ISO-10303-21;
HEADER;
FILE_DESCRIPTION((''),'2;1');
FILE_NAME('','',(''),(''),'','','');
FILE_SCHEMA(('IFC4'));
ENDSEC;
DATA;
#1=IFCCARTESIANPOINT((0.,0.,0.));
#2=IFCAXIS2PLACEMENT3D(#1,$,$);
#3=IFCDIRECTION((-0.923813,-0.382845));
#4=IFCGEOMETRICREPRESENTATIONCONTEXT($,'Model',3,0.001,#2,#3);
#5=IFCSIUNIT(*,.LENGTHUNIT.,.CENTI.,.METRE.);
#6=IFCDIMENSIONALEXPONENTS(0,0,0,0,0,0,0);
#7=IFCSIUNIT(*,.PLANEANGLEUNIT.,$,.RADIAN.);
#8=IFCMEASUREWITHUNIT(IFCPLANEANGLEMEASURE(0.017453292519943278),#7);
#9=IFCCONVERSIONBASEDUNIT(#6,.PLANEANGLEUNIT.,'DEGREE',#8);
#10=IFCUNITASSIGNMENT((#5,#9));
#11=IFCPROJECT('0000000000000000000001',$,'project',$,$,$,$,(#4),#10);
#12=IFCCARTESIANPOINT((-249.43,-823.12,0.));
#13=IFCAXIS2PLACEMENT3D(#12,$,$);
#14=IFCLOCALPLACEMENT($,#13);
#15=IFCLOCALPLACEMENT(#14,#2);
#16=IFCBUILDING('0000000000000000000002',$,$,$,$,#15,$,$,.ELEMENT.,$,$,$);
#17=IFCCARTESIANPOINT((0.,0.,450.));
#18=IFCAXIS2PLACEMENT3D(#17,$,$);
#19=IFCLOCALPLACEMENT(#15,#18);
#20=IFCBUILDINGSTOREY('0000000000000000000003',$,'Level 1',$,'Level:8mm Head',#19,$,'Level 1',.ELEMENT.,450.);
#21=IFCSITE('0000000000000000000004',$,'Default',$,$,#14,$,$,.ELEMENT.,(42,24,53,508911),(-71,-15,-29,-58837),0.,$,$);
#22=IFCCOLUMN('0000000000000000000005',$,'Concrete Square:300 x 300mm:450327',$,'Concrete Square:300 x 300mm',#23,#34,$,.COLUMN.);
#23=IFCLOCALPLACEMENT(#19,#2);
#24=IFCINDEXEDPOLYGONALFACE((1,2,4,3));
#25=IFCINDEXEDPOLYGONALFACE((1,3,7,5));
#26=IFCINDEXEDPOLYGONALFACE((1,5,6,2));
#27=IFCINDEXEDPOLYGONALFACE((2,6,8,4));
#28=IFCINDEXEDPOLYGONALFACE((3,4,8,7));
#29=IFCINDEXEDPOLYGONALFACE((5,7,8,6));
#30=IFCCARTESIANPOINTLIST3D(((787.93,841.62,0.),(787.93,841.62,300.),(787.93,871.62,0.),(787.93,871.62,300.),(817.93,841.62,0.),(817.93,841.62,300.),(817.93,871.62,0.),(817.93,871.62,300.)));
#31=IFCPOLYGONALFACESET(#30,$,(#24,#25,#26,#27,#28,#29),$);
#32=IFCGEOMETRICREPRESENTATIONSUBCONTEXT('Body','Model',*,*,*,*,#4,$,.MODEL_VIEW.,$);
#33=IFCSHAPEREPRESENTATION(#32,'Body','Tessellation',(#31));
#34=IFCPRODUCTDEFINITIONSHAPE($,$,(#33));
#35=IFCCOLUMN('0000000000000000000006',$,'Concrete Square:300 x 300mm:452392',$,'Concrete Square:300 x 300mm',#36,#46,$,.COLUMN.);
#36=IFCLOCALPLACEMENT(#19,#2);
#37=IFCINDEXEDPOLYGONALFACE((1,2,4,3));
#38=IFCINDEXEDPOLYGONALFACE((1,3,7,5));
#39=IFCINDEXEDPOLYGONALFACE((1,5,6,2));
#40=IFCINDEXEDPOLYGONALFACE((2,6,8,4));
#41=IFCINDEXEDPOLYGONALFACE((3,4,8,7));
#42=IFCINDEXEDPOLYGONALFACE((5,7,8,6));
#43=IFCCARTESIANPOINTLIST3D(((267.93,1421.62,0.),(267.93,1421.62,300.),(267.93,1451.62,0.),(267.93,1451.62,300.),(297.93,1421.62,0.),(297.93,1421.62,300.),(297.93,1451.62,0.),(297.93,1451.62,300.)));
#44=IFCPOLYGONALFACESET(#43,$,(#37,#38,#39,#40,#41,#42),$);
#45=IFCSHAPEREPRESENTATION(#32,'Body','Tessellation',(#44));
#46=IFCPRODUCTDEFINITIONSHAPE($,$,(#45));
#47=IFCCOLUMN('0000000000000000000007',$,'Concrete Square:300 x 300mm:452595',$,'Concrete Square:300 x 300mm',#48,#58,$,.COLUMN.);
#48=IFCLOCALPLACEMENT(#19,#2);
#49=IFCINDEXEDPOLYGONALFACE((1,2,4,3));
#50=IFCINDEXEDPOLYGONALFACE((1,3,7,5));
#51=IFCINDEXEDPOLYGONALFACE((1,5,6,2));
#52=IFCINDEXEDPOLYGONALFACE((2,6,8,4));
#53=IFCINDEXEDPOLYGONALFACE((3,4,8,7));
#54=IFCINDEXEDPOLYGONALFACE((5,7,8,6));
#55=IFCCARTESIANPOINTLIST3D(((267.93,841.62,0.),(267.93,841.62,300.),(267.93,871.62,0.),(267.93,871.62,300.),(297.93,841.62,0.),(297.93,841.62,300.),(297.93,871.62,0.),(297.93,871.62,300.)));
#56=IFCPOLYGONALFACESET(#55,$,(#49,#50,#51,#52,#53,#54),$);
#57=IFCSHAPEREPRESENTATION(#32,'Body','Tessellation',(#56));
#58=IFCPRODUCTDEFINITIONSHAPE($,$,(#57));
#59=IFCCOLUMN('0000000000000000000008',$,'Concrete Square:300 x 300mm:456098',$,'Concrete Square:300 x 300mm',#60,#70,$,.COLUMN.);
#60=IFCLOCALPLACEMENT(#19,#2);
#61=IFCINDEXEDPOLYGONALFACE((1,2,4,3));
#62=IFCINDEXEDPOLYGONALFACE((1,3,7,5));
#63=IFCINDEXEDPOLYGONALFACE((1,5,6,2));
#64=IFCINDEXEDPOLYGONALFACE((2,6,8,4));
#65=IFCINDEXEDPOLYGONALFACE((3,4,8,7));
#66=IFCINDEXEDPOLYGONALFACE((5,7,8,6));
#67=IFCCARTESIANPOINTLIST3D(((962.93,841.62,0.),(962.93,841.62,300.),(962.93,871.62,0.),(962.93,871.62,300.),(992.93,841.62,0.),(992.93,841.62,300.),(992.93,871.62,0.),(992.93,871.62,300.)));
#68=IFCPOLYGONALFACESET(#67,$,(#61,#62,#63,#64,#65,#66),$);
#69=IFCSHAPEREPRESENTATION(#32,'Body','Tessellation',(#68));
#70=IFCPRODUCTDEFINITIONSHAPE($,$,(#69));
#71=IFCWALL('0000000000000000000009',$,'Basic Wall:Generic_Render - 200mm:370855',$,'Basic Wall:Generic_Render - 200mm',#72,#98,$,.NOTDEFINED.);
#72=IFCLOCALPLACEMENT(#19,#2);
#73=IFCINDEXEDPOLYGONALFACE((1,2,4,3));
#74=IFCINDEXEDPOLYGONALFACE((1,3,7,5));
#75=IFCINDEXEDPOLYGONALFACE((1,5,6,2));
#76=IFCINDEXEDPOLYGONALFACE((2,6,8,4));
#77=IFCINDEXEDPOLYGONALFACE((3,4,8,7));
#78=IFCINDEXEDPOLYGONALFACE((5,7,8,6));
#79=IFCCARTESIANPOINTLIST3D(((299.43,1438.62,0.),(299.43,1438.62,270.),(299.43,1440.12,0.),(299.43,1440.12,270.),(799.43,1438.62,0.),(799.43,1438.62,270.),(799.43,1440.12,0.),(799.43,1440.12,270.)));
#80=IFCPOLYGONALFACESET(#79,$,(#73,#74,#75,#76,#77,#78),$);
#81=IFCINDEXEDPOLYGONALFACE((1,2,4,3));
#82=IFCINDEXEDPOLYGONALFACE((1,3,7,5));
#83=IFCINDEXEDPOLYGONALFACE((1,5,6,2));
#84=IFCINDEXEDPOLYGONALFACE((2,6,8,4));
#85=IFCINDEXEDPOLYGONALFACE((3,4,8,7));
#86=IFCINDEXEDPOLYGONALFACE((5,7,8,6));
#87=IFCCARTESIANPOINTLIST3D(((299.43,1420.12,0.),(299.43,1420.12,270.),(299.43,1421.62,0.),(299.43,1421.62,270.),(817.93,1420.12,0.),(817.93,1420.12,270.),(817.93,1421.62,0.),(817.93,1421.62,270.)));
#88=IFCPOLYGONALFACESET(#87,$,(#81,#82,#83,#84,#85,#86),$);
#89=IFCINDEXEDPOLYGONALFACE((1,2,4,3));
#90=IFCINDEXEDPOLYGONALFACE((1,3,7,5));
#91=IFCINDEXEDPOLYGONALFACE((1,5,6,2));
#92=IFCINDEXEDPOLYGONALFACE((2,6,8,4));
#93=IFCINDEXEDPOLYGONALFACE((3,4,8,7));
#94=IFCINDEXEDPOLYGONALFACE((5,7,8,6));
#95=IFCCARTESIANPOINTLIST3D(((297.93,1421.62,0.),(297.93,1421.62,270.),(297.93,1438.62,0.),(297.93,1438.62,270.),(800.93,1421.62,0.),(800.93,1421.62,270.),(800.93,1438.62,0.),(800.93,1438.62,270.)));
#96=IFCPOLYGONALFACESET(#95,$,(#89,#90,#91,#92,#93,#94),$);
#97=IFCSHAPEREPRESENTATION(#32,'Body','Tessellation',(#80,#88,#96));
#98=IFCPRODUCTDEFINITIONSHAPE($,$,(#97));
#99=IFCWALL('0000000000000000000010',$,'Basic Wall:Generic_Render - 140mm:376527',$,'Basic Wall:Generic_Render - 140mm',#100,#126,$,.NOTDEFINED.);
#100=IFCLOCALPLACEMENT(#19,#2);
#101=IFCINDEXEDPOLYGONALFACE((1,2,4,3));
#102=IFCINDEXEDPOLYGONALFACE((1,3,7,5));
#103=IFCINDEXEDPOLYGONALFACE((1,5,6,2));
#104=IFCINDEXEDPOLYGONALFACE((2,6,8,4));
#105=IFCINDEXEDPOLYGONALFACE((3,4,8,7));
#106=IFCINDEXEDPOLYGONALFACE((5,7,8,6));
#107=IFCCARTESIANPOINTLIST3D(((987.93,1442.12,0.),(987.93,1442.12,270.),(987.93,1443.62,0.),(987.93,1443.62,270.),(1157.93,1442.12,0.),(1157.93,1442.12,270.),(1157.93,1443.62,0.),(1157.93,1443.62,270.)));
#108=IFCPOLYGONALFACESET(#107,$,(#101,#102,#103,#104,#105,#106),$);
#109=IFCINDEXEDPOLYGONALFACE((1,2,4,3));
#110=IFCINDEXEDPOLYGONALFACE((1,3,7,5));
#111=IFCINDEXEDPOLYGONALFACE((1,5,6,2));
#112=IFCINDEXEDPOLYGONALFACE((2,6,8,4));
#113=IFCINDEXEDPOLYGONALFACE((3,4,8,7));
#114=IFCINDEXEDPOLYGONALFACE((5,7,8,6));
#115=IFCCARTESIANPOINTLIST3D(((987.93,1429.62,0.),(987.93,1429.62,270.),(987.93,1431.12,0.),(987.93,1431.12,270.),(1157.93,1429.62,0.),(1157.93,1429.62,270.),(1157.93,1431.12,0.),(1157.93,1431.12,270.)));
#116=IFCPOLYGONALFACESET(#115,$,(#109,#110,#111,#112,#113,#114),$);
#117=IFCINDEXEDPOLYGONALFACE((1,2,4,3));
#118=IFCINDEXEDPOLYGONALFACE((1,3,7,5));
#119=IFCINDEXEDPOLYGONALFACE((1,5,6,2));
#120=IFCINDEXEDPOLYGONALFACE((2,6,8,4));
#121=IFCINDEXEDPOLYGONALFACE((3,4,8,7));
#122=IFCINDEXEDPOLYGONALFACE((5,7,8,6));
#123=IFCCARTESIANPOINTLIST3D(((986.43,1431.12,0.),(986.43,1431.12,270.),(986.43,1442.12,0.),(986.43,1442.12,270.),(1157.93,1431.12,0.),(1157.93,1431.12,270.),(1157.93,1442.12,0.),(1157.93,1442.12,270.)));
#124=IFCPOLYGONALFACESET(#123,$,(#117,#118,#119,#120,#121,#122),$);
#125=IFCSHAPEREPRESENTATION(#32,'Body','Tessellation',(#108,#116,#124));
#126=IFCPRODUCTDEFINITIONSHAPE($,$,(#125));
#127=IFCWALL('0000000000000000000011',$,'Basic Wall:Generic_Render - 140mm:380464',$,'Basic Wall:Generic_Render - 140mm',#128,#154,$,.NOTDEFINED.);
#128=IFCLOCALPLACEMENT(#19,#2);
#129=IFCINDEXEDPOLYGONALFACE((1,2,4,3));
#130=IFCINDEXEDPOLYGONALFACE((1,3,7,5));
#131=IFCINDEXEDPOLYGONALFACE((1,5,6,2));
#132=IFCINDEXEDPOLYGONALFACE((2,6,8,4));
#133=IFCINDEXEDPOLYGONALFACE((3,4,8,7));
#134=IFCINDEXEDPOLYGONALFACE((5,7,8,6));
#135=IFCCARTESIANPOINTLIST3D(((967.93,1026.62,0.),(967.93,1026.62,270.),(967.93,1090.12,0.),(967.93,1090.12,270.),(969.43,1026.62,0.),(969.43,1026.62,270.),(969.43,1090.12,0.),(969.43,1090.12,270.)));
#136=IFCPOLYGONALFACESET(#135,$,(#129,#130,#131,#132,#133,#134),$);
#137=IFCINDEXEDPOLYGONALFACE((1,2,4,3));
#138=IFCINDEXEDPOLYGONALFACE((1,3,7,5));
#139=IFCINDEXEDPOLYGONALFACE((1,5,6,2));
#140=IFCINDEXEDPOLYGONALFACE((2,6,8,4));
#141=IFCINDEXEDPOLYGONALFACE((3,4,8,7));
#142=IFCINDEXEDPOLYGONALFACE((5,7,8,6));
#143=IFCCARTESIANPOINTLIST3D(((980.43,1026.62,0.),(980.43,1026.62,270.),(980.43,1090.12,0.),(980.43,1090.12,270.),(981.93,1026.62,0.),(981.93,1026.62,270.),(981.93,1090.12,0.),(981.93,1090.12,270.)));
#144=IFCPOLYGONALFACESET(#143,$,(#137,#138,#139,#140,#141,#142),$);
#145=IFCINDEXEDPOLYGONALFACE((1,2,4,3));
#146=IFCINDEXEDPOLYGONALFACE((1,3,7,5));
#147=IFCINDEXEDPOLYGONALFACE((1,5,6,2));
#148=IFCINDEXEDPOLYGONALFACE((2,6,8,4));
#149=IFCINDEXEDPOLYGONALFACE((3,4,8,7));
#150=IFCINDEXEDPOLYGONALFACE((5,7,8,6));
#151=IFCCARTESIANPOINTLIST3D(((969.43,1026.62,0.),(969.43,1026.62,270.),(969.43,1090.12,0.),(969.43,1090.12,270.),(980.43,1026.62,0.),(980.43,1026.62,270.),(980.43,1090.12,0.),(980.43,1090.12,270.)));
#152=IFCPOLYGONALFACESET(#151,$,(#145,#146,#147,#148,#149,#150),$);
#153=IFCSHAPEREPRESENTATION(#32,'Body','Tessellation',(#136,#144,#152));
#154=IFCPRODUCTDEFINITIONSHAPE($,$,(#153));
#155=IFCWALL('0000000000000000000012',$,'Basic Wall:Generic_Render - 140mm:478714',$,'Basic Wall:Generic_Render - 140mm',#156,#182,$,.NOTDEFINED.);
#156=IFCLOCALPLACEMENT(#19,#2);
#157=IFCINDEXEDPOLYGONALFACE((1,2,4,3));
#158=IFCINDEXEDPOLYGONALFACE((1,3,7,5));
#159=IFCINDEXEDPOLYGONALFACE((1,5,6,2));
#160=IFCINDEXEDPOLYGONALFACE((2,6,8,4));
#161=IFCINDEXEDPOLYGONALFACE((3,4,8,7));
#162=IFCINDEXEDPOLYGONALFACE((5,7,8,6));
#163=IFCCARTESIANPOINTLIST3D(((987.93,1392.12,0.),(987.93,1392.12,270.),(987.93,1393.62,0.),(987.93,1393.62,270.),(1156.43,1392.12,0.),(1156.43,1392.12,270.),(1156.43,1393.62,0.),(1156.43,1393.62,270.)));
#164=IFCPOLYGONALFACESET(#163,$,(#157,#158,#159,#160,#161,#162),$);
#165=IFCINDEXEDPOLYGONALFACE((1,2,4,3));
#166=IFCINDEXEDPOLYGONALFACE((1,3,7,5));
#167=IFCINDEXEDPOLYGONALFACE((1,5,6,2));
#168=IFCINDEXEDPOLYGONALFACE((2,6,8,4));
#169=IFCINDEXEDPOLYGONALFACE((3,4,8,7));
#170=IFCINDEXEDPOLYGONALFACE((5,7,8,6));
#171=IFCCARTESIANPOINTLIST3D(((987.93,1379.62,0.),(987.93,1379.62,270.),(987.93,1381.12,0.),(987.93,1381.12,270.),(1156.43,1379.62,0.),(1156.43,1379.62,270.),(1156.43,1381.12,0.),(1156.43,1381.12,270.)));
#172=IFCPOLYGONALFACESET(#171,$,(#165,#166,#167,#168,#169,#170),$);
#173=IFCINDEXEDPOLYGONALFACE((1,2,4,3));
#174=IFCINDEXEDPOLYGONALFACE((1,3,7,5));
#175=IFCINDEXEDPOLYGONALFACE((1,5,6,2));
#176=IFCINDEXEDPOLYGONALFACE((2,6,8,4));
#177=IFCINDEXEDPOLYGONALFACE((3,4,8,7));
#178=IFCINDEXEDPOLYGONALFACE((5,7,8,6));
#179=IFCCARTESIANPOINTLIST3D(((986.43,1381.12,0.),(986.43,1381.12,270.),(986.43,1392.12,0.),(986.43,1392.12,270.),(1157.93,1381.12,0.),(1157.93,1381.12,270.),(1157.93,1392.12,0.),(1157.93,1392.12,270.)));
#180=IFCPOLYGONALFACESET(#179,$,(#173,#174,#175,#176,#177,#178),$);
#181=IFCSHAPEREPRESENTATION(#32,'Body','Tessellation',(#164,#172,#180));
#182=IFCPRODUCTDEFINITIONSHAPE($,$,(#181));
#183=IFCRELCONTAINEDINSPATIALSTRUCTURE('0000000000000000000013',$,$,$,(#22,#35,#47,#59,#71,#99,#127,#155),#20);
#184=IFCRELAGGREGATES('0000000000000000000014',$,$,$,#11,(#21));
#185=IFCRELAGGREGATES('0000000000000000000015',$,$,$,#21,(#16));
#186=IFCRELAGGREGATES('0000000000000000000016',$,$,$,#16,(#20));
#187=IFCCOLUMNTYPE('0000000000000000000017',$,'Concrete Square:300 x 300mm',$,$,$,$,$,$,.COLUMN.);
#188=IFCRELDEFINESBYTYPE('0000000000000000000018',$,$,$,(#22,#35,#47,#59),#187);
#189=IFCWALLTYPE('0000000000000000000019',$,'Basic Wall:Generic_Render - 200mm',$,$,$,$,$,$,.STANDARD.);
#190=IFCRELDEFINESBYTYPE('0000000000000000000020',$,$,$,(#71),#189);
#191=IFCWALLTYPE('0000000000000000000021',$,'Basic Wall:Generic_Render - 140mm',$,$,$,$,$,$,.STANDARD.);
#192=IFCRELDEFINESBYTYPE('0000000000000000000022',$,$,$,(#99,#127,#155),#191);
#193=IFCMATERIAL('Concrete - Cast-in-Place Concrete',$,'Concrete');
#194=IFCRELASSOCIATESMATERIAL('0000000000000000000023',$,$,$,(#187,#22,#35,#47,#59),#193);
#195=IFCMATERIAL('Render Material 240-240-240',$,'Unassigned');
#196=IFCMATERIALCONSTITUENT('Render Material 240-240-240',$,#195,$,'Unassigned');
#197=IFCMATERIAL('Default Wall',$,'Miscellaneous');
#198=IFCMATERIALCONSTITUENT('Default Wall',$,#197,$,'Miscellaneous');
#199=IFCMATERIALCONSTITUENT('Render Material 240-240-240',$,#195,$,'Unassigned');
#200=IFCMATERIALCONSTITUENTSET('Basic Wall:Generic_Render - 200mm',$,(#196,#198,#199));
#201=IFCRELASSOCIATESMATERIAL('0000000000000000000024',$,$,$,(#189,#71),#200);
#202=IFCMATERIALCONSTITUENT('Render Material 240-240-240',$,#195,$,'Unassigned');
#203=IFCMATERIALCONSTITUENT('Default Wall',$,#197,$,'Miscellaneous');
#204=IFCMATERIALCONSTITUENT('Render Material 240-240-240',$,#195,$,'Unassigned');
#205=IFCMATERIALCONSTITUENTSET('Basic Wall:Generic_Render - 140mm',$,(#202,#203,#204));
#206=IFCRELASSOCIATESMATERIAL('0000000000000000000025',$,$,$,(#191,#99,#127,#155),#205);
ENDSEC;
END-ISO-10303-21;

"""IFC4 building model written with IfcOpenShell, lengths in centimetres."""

from ifc_helpers import new_model, entity, si_unit, converted_unit, direction, frame, origin, place, context, subcontext, project, spatial, indexed_curve, outline, extrude, source, transform, mapped, material, constituent, constituent_set, type_object, type_shapes, element, save


model = new_model("IFC4")

# Units and contexts
model_context = context("Model", 3, precision=0.001, world=origin(), true_north=direction((-0.923813, -0.382845)))
body_context = subcontext(model_context, "Body", "Model", "MODEL_VIEW")
ifc_project = project(units=[si_unit("LENGTHUNIT", "METRE", prefix="CENTI"), converted_unit("PLANEANGLEUNIT", "DEGREE", entity("IfcPlaneAngleMeasure", 0.017453292519943278), si_unit("PLANEANGLEUNIT", "RADIAN"), dimensions=[0, 0, 0, 0, 0, 0, 0])], contexts=[model_context])

# Site, building, storey
site_placement = place(None, frame((-249.43, -823.12, 0.0)))
site = spatial("IfcSite", under=ifc_project, at=site_placement, Name="Default", CompositionType="ELEMENT", RefLatitude=(42, 24, 53, 508911), RefLongitude=(-71, -15, -29, -58837), RefElevation=0.0)
building_placement = place(site_placement, origin())
building = spatial("IfcBuilding", under=site, at=building_placement, CompositionType="ELEMENT")
storey_placement = place(building_placement, frame((0.0, 0.0, 450.0)))
storey = spatial("IfcBuildingStorey", under=building, at=storey_placement, Name="Level 1", ObjectType="Level:8mm Head", LongName="Level 1", CompositionType="ELEMENT", Elevation=450.0)

# Columns
ifc_material_1 = material(Name="Concrete - Cast-in-Place Concrete", Category="Concrete")
column_type = type_object("IfcColumnType", Name="Concrete Square:300 x 300mm", PredefinedType="COLUMN", material=ifc_material_1)
shared_shape_1 = source(origin(), body_context, "Body", "SweptSolid", [
    extrude(outline(indexed_curve([(-15.0, -15.0), (15.0, -15.0), (15.0, 15.0), (-15.0, 15.0), (-15.0, -15.0)], self_intersect=False)), frame((0.0, 0.0, 450.0), z_axis=(0.0, 0.0, 1.0), x_axis=(-1.0, 0.0, 0.0)), (0.0, 0.0, 1.0), 300.0),
])
type_shapes(column_type, [shared_shape_1])
for number, where, name in (
    (1, (802.93, 856.62, -450.0), "Concrete Square:300 x 300mm:450327"),
    (2, (282.93, 1436.62, -450.0), "Concrete Square:300 x 300mm:452392"),
    (3, (282.93, 856.62, -450.0), "Concrete Square:300 x 300mm:452595"),
    (4, (977.93, 856.62, -450.0), "Concrete Square:300 x 300mm:456098"),
):
    element("IfcColumn", number, at=place(storey_placement, frame(where)), inside=storey, type_object=column_type, material=ifc_material_1, Name=name, ObjectType="Concrete Square:300 x 300mm", PredefinedType="COLUMN", context=body_context, shape_type="MappedRepresentation", body=[
        mapped(shared_shape_1, transform((0.0, 0.0, 0.0), scale=1.0)),
    ])

# Walls
ifc_material_2 = material(Name="Render Material 240-240-240", Category="Unassigned")
ifc_constituent_1 = constituent(ifc_material_2, Name="Render Material 240-240-240", Category="Unassigned")
ifc_material_3 = material(Name="Default Wall", Category="Miscellaneous")
ifc_constituent_2 = constituent(ifc_material_3, Name="Default Wall", Category="Miscellaneous")
ifc_constituent_3 = constituent(ifc_material_2, Name="Render Material 240-240-240", Category="Unassigned")
ifc_constituent_set_1 = constituent_set(constituents=[ifc_constituent_1, ifc_constituent_2, ifc_constituent_3], Name="Basic Wall:Generic_Render - 200mm")
wall_type_1 = type_object("IfcWallType", Name="Basic Wall:Generic_Render - 200mm", PredefinedType="STANDARD", material=ifc_constituent_set_1)
wall_1_placement = place(storey_placement, frame((799.43, 1430.12, 0.0), z_axis=(0.0, 0.0, 1.0), x_axis=(-1.0, 0.0, 0.0)))
element("IfcWall", 5, at=wall_1_placement, inside=storey, type_object=wall_type_1, material=ifc_constituent_set_1, Name="Basic Wall:Generic_Render - 200mm:370855", ObjectType="Basic Wall:Generic_Render - 200mm", PredefinedType="NOTDEFINED", context=body_context, shape_type="SweptSolid", body=[
    extrude(outline(indexed_curve([(-0.75, -250.0), (0.75, -250.0), (0.75, 250.0), (-0.75, 250.0), (-0.75, -250.0)], self_intersect=False)), frame((250.0, -9.25, 0.0), z_axis=(0.0, 0.0, 1.0), x_axis=(0.0, 1.0, 0.0)), (0.0, 0.0, 1.0), 270.0),
    extrude(outline(indexed_curve([(-0.75, -259.25), (0.75, -259.25), (0.75, 259.25), (-0.75, 259.25), (-0.75, -259.25)], self_intersect=False)), frame((240.75, 9.25, 0.0), z_axis=(0.0, 0.0, 1.0), x_axis=(0.0, -1.0, 0.0)), (0.0, 0.0, 1.0), 270.0),
    extrude(outline(indexed_curve([(-251.5, -8.5), (251.5, -8.5), (251.5, 8.5), (-251.5, 8.5), (-251.5, -8.5)], self_intersect=False)), frame((250.0, 0.0, 0.0)), (0.0, 0.0, 1.0), 270.0),
])
ifc_constituent_4 = constituent(ifc_material_2, Name="Render Material 240-240-240", Category="Unassigned")
ifc_constituent_5 = constituent(ifc_material_3, Name="Default Wall", Category="Miscellaneous")
ifc_constituent_6 = constituent(ifc_material_2, Name="Render Material 240-240-240", Category="Unassigned")
ifc_constituent_set_2 = constituent_set(constituents=[ifc_constituent_4, ifc_constituent_5, ifc_constituent_6], Name="Basic Wall:Generic_Render - 140mm")
wall_type_2 = type_object("IfcWallType", Name="Basic Wall:Generic_Render - 140mm", PredefinedType="STANDARD", material=ifc_constituent_set_2)
wall_2_placement = place(storey_placement, frame((1157.93, 1436.62, 0.0), z_axis=(0.0, 0.0, 1.0), x_axis=(-1.0, 0.0, 0.0)))
element("IfcWall", 6, at=wall_2_placement, inside=storey, type_object=wall_type_2, material=ifc_constituent_set_2, Name="Basic Wall:Generic_Render - 140mm:376527", ObjectType="Basic Wall:Generic_Render - 140mm", PredefinedType="NOTDEFINED", context=body_context, shape_type="SweptSolid", body=[
    extrude(outline(indexed_curve([(-0.75, -85.0), (0.75, -85.0), (0.75, 85.0), (-0.75, 85.0), (-0.75, -85.0)], self_intersect=False)), frame((85.0, -6.25, 0.0), z_axis=(0.0, 0.0, 1.0), x_axis=(0.0, 1.0, 0.0)), (0.0, 0.0, 1.0), 270.0),
    extrude(outline(indexed_curve([(-0.75, -85.0), (0.75, -85.0), (0.75, 85.0), (-0.75, 85.0), (-0.75, -85.0)], self_intersect=False)), frame((85.0, 6.25, 0.0), z_axis=(0.0, 0.0, 1.0), x_axis=(0.0, -1.0, 0.0)), (0.0, 0.0, 1.0), 270.0),
    extrude(outline(indexed_curve([(-85.75, -5.5), (85.75, -5.5), (85.75, 5.5), (-85.75, 5.5), (-85.75, -5.5)], self_intersect=False)), frame((85.75, 0.0, 0.0)), (0.0, 0.0, 1.0), 270.0),
])
wall_3_placement = place(storey_placement, frame((974.93, 1090.12, 0.0), z_axis=(0.0, 0.0, 1.0), x_axis=(0.0, -1.0, 0.0)))
element("IfcWall", 7, at=wall_3_placement, inside=storey, type_object=wall_type_2, material=ifc_constituent_set_2, Name="Basic Wall:Generic_Render - 140mm:380464", ObjectType="Basic Wall:Generic_Render - 140mm", PredefinedType="NOTDEFINED", context=body_context, shape_type="SweptSolid", body=[
    extrude(outline(indexed_curve([(-0.75, -31.75), (0.75, -31.75), (0.75, 31.75), (-0.75, 31.75), (-0.75, -31.75)], self_intersect=False)), frame((31.75, -6.25, 0.0), z_axis=(0.0, 0.0, 1.0), x_axis=(0.0, 1.0, 0.0)), (0.0, 0.0, 1.0), 270.0),
    extrude(outline(indexed_curve([(-0.75, -31.75), (0.75, -31.75), (0.75, 31.75), (-0.75, 31.75), (-0.75, -31.75)], self_intersect=False)), frame((31.75, 6.25, 0.0), z_axis=(0.0, 0.0, 1.0), x_axis=(0.0, -1.0, 0.0)), (0.0, 0.0, 1.0), 270.0),
    extrude(outline(indexed_curve([(-31.75, -5.5), (31.75, -5.5), (31.75, 5.5), (-31.75, 5.5), (-31.75, -5.5)], self_intersect=False)), frame((31.75, 0.0, 0.0)), (0.0, 0.0, 1.0), 270.0),
])
wall_4_placement = place(storey_placement, frame((1156.43, 1386.62, 0.0), z_axis=(0.0, 0.0, 1.0), x_axis=(-1.0, 0.0, 0.0)))
element("IfcWall", 8, at=wall_4_placement, inside=storey, type_object=wall_type_2, material=ifc_constituent_set_2, Name="Basic Wall:Generic_Render - 140mm:478714", ObjectType="Basic Wall:Generic_Render - 140mm", PredefinedType="NOTDEFINED", context=body_context, shape_type="SweptSolid", body=[
    extrude(outline(indexed_curve([(-0.75, -84.25), (0.75, -84.25), (0.75, 84.25), (-0.75, 84.25), (-0.75, -84.25)], self_intersect=False)), frame((84.25, -6.25, 0.0), z_axis=(0.0, 0.0, 1.0), x_axis=(0.0, 1.0, 0.0)), (0.0, 0.0, 1.0), 270.0),
    extrude(outline(indexed_curve([(-0.75, -84.25), (0.75, -84.25), (0.75, 84.25), (-0.75, 84.25), (-0.75, -84.25)], self_intersect=False)), frame((84.25, 6.25, 0.0), z_axis=(0.0, 0.0, 1.0), x_axis=(0.0, -1.0, 0.0)), (0.0, 0.0, 1.0), 270.0),
    extrude(outline(indexed_curve([(-85.75, -5.5), (85.75, -5.5), (85.75, 5.5), (-85.75, 5.5), (-85.75, -5.5)], self_intersect=False)), frame((84.25, 0.0, 0.0)), (0.0, 0.0, 1.0), 270.0),
])

save(model, "model.ifc")
